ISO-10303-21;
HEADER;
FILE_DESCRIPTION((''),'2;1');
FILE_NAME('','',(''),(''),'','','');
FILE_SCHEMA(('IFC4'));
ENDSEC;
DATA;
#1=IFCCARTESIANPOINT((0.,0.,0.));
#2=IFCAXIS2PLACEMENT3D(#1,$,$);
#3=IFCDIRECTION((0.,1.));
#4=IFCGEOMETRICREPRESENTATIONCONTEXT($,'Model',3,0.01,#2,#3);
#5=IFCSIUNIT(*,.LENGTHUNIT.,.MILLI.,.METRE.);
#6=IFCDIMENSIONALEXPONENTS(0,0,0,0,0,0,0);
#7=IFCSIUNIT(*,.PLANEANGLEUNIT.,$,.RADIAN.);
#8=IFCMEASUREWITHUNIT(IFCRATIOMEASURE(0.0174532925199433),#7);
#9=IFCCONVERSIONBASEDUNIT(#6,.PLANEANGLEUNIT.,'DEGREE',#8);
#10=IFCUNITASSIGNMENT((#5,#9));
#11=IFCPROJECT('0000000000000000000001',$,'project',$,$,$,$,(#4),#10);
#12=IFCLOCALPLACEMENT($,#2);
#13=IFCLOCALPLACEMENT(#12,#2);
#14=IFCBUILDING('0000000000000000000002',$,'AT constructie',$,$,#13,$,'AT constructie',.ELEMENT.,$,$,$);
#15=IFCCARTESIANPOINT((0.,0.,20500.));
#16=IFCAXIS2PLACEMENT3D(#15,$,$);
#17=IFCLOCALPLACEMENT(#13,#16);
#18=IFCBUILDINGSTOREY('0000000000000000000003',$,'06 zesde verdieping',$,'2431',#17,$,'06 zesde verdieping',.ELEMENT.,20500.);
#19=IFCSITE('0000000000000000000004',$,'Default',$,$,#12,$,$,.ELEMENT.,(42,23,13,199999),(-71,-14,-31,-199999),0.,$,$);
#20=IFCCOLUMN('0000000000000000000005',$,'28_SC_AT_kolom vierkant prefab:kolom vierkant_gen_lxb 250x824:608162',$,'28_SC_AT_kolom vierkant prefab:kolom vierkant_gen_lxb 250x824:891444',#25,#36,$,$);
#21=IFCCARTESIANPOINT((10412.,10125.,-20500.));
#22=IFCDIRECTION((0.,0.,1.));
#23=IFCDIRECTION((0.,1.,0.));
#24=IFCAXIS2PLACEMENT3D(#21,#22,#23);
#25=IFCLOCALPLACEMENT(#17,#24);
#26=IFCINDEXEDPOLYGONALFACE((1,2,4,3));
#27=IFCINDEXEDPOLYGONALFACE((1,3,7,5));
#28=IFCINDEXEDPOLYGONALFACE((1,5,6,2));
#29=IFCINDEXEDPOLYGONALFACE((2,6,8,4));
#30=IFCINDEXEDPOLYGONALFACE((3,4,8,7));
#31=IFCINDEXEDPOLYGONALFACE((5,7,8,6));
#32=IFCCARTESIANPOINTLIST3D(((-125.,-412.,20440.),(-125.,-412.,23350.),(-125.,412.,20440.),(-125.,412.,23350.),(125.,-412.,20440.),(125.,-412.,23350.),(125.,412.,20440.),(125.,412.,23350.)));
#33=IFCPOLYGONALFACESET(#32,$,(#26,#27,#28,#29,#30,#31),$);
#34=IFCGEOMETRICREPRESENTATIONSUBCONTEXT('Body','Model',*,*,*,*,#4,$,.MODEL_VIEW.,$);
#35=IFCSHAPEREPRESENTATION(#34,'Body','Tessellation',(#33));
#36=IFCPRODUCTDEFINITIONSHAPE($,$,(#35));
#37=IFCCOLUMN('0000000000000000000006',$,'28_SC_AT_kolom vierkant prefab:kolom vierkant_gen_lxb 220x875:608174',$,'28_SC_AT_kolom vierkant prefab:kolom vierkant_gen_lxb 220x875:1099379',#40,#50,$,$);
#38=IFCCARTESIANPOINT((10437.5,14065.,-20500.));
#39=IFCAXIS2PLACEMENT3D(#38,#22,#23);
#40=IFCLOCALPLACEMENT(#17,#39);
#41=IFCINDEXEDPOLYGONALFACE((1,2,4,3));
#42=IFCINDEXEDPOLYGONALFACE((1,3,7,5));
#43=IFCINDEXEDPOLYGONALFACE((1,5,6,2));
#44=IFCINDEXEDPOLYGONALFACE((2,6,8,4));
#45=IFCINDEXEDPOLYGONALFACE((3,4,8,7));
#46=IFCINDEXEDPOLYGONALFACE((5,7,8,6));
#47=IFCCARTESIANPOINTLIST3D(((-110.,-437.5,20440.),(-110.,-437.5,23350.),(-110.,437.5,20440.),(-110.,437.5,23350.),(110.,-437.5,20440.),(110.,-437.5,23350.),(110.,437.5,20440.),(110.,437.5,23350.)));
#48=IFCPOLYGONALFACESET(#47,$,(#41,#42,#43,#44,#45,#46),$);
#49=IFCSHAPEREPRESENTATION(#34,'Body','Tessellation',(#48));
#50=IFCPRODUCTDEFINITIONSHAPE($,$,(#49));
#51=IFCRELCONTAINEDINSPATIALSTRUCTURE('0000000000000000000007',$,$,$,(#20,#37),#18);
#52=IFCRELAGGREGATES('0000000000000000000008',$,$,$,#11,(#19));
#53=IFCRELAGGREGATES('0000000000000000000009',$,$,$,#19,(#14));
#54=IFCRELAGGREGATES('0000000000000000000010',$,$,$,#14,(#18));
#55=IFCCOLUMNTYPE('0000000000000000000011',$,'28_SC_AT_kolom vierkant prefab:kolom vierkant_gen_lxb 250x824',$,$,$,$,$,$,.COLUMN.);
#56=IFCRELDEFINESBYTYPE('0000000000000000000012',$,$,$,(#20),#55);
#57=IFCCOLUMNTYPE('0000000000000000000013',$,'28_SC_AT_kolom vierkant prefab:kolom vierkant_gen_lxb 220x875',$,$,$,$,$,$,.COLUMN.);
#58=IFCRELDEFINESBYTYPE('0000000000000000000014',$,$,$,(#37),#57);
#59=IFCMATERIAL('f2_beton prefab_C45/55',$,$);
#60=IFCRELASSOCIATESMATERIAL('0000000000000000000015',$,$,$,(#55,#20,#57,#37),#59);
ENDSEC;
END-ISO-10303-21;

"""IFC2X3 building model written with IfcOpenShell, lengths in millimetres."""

from ifc_helpers import new_model, entity, si_unit, converted_unit, direction, frame, origin, origin_2d_with_axis, place, context, subcontext, project, spatial, rectangle, extrude, source, transform, mapped, material, type_object, type_shapes, element, save


model = new_model("IFC2X3")

# Units and contexts
model_context = context("Model", 3, precision=0.01, world=origin(), true_north=direction((0.0, 1.0)))
body_context = subcontext(model_context, "Body", "Model", "MODEL_VIEW")
ifc_project = project(units=[si_unit("LENGTHUNIT", "METRE", prefix="MILLI"), converted_unit("PLANEANGLEUNIT", "DEGREE", entity("IfcRatioMeasure", 0.0174532925199433), si_unit("PLANEANGLEUNIT", "RADIAN"), dimensions=[0, 0, 0, 0, 0, 0, 0])], contexts=[model_context])

# Site, building, storey
site_placement = place(None, origin())
site = spatial("IfcSite", under=ifc_project, at=site_placement, Name="Default", CompositionType="ELEMENT", RefLatitude=(42, 23, 13, 199999), RefLongitude=(-71, -14, -31, -199999), RefElevation=0.0)
building_placement = place(site_placement, origin())
building = spatial("IfcBuilding", under=site, at=building_placement, Name="AT constructie", LongName="AT constructie", CompositionType="ELEMENT")
storey_placement = place(building_placement, frame((0.0, 0.0, 20500.0)))
storey = spatial("IfcBuildingStorey", under=building, at=storey_placement, Name="06 zesde verdieping", ObjectType="2431", LongName="06 zesde verdieping", CompositionType="ELEMENT", Elevation=20500.0)

# Columns
ifc_material = material(Name="f2_beton prefab_C45/55")
column_type_1 = type_object("IfcColumnType", Name="28_SC_AT_kolom vierkant prefab:kolom vierkant_gen_lxb 250x824", PredefinedType="COLUMN", material=ifc_material)
shared_shape_1 = source(origin(), body_context, "Body", "SweptSolid", [
    extrude(rectangle(XDim=250.0, YDim=824.0, at=origin_2d_with_axis()), frame((0.0, 0.0, 20440.0), z_axis=(0.0, 0.0, 1.0), x_axis=(-1.0, 0.0, 0.0)), (0.0, 0.0, 1.0), 2910.0),
])
type_shapes(column_type_1, [shared_shape_1])
column_1_placement = place(storey_placement, frame((10412.0, 10125.0, -20500.0), z_axis=(0.0, 0.0, 1.0), x_axis=(0.0, 1.0, 0.0)))
element("IfcColumn", 1, at=column_1_placement, inside=storey, type_object=column_type_1, material=ifc_material, Name="28_SC_AT_kolom vierkant prefab:kolom vierkant_gen_lxb 250x824:608162", ObjectType="28_SC_AT_kolom vierkant prefab:kolom vierkant_gen_lxb 250x824:891444", context=body_context, shape_type="MappedRepresentation", body=[
    mapped(shared_shape_1, transform((0.0, 0.0, 0.0), scale=1.0)),
])
column_type_2 = type_object("IfcColumnType", Name="28_SC_AT_kolom vierkant prefab:kolom vierkant_gen_lxb 220x875", PredefinedType="COLUMN", material=ifc_material)
shared_shape_2 = source(origin(), body_context, "Body", "SweptSolid", [
    extrude(rectangle(XDim=220.0, YDim=875.0, at=origin_2d_with_axis()), frame((0.0, 0.0, 20440.0), z_axis=(0.0, 0.0, 1.0), x_axis=(-1.0, 0.0, 0.0)), (0.0, 0.0, 1.0), 2910.0),
])
type_shapes(column_type_2, [shared_shape_2])
column_2_placement = place(storey_placement, frame((10437.5, 14065.0, -20500.0), z_axis=(0.0, 0.0, 1.0), x_axis=(0.0, 1.0, 0.0)))
element("IfcColumn", 2, at=column_2_placement, inside=storey, type_object=column_type_2, material=ifc_material, Name="28_SC_AT_kolom vierkant prefab:kolom vierkant_gen_lxb 220x875:608174", ObjectType="28_SC_AT_kolom vierkant prefab:kolom vierkant_gen_lxb 220x875:1099379", context=body_context, shape_type="MappedRepresentation", body=[
    mapped(shared_shape_2, transform((0.0, 0.0, 0.0), scale=1.0)),
])

save(model, "model.ifc")
